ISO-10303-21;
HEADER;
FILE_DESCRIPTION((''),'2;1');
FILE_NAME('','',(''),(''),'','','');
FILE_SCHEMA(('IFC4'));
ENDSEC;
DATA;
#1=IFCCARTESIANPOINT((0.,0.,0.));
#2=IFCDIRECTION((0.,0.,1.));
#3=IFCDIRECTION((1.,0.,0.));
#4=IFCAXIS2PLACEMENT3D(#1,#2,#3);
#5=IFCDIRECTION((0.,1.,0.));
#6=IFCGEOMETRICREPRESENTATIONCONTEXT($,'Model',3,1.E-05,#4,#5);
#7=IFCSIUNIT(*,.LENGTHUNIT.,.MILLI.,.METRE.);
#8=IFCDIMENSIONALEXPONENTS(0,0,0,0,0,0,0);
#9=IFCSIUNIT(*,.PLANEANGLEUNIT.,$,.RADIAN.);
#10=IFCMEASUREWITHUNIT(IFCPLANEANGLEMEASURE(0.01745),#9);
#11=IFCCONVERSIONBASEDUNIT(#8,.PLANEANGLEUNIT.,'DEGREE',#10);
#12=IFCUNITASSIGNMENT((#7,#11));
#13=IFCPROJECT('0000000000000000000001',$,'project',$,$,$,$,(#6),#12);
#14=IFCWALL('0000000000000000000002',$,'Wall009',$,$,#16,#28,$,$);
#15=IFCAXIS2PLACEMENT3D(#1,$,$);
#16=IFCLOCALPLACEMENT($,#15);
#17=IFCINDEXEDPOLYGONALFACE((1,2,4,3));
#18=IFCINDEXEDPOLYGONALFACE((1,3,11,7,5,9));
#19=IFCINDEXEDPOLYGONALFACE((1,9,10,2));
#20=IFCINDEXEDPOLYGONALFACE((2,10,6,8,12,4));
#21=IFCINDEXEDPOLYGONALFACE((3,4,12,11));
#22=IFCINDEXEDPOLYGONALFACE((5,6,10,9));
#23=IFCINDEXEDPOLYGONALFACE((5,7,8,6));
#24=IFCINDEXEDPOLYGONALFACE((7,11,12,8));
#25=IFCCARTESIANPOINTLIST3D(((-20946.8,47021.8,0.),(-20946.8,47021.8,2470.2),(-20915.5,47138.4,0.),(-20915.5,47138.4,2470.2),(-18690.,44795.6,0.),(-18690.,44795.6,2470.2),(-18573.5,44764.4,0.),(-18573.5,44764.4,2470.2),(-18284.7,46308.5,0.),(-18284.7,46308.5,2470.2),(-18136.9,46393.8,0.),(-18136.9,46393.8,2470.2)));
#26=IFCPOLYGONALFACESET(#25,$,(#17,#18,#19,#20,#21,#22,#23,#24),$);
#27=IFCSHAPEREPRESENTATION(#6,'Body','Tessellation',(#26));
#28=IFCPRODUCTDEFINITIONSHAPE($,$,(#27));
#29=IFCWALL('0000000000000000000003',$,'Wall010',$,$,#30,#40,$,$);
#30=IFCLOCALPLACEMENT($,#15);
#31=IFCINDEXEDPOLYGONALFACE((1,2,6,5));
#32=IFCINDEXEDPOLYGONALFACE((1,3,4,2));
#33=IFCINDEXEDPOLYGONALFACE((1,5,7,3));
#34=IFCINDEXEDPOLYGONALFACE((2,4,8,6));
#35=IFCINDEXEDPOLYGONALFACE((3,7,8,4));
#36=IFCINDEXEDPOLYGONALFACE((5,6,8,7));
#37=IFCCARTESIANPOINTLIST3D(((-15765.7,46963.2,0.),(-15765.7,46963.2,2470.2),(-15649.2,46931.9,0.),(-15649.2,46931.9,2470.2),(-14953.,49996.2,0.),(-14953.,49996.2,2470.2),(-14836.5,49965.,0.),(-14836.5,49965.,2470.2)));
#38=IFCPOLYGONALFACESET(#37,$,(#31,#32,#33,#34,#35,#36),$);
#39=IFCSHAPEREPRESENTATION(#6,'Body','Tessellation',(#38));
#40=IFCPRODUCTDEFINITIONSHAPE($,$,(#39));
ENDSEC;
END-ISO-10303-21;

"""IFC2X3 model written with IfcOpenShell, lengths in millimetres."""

from ifc_helpers import new_model, entity, si_unit, converted_unit, direction, origin_with_axes, place, context, project, polyline, outline, extrude, element, save


model = new_model("IFC2X3")

# Units and contexts
model_context = context("Model", 3, precision=1e-05, world=origin_with_axes(), true_north=direction((0.0, 1.0, 0.0)))
ifc_project = project(units=[si_unit("LENGTHUNIT", "METRE", prefix="MILLI"), converted_unit("PLANEANGLEUNIT", "DEGREE", entity("IfcPlaneAngleMeasure", 0.01745), si_unit("PLANEANGLEUNIT", "RADIAN"), dimensions=[0, 0, 0, 0, 0, 0, 0])], contexts=[model_context])

# Walls
wall_1_placement = place(None, origin_with_axes())
element("IfcWall", 1, at=wall_1_placement, Name="Wall009", context=model_context, shape_type="SweptSolid", body=[
    extrude(outline(polyline([(-18573.5, 44764.4), (-18136.9, 46393.8), (-20915.5, 47138.4), (-20946.8, 47021.8), (-18284.7, 46308.5), (-18690.0, 44795.6), (-18573.5, 44764.4)])), origin_with_axes(), (0.0, 0.0, 1.0), 2470.2),
])
wall_2_placement = place(None, origin_with_axes())
element("IfcWall", 2, at=wall_2_placement, Name="Wall010", context=model_context, shape_type="SweptSolid", body=[
    extrude(outline(polyline([(-15765.7, 46963.2), (-14953.0, 49996.2), (-14836.5, 49965.0), (-15649.2, 46931.9), (-15765.7, 46963.2)])), origin_with_axes(), (0.0, 0.0, 1.0), 2470.2),
])

save(model, "model.ifc")
